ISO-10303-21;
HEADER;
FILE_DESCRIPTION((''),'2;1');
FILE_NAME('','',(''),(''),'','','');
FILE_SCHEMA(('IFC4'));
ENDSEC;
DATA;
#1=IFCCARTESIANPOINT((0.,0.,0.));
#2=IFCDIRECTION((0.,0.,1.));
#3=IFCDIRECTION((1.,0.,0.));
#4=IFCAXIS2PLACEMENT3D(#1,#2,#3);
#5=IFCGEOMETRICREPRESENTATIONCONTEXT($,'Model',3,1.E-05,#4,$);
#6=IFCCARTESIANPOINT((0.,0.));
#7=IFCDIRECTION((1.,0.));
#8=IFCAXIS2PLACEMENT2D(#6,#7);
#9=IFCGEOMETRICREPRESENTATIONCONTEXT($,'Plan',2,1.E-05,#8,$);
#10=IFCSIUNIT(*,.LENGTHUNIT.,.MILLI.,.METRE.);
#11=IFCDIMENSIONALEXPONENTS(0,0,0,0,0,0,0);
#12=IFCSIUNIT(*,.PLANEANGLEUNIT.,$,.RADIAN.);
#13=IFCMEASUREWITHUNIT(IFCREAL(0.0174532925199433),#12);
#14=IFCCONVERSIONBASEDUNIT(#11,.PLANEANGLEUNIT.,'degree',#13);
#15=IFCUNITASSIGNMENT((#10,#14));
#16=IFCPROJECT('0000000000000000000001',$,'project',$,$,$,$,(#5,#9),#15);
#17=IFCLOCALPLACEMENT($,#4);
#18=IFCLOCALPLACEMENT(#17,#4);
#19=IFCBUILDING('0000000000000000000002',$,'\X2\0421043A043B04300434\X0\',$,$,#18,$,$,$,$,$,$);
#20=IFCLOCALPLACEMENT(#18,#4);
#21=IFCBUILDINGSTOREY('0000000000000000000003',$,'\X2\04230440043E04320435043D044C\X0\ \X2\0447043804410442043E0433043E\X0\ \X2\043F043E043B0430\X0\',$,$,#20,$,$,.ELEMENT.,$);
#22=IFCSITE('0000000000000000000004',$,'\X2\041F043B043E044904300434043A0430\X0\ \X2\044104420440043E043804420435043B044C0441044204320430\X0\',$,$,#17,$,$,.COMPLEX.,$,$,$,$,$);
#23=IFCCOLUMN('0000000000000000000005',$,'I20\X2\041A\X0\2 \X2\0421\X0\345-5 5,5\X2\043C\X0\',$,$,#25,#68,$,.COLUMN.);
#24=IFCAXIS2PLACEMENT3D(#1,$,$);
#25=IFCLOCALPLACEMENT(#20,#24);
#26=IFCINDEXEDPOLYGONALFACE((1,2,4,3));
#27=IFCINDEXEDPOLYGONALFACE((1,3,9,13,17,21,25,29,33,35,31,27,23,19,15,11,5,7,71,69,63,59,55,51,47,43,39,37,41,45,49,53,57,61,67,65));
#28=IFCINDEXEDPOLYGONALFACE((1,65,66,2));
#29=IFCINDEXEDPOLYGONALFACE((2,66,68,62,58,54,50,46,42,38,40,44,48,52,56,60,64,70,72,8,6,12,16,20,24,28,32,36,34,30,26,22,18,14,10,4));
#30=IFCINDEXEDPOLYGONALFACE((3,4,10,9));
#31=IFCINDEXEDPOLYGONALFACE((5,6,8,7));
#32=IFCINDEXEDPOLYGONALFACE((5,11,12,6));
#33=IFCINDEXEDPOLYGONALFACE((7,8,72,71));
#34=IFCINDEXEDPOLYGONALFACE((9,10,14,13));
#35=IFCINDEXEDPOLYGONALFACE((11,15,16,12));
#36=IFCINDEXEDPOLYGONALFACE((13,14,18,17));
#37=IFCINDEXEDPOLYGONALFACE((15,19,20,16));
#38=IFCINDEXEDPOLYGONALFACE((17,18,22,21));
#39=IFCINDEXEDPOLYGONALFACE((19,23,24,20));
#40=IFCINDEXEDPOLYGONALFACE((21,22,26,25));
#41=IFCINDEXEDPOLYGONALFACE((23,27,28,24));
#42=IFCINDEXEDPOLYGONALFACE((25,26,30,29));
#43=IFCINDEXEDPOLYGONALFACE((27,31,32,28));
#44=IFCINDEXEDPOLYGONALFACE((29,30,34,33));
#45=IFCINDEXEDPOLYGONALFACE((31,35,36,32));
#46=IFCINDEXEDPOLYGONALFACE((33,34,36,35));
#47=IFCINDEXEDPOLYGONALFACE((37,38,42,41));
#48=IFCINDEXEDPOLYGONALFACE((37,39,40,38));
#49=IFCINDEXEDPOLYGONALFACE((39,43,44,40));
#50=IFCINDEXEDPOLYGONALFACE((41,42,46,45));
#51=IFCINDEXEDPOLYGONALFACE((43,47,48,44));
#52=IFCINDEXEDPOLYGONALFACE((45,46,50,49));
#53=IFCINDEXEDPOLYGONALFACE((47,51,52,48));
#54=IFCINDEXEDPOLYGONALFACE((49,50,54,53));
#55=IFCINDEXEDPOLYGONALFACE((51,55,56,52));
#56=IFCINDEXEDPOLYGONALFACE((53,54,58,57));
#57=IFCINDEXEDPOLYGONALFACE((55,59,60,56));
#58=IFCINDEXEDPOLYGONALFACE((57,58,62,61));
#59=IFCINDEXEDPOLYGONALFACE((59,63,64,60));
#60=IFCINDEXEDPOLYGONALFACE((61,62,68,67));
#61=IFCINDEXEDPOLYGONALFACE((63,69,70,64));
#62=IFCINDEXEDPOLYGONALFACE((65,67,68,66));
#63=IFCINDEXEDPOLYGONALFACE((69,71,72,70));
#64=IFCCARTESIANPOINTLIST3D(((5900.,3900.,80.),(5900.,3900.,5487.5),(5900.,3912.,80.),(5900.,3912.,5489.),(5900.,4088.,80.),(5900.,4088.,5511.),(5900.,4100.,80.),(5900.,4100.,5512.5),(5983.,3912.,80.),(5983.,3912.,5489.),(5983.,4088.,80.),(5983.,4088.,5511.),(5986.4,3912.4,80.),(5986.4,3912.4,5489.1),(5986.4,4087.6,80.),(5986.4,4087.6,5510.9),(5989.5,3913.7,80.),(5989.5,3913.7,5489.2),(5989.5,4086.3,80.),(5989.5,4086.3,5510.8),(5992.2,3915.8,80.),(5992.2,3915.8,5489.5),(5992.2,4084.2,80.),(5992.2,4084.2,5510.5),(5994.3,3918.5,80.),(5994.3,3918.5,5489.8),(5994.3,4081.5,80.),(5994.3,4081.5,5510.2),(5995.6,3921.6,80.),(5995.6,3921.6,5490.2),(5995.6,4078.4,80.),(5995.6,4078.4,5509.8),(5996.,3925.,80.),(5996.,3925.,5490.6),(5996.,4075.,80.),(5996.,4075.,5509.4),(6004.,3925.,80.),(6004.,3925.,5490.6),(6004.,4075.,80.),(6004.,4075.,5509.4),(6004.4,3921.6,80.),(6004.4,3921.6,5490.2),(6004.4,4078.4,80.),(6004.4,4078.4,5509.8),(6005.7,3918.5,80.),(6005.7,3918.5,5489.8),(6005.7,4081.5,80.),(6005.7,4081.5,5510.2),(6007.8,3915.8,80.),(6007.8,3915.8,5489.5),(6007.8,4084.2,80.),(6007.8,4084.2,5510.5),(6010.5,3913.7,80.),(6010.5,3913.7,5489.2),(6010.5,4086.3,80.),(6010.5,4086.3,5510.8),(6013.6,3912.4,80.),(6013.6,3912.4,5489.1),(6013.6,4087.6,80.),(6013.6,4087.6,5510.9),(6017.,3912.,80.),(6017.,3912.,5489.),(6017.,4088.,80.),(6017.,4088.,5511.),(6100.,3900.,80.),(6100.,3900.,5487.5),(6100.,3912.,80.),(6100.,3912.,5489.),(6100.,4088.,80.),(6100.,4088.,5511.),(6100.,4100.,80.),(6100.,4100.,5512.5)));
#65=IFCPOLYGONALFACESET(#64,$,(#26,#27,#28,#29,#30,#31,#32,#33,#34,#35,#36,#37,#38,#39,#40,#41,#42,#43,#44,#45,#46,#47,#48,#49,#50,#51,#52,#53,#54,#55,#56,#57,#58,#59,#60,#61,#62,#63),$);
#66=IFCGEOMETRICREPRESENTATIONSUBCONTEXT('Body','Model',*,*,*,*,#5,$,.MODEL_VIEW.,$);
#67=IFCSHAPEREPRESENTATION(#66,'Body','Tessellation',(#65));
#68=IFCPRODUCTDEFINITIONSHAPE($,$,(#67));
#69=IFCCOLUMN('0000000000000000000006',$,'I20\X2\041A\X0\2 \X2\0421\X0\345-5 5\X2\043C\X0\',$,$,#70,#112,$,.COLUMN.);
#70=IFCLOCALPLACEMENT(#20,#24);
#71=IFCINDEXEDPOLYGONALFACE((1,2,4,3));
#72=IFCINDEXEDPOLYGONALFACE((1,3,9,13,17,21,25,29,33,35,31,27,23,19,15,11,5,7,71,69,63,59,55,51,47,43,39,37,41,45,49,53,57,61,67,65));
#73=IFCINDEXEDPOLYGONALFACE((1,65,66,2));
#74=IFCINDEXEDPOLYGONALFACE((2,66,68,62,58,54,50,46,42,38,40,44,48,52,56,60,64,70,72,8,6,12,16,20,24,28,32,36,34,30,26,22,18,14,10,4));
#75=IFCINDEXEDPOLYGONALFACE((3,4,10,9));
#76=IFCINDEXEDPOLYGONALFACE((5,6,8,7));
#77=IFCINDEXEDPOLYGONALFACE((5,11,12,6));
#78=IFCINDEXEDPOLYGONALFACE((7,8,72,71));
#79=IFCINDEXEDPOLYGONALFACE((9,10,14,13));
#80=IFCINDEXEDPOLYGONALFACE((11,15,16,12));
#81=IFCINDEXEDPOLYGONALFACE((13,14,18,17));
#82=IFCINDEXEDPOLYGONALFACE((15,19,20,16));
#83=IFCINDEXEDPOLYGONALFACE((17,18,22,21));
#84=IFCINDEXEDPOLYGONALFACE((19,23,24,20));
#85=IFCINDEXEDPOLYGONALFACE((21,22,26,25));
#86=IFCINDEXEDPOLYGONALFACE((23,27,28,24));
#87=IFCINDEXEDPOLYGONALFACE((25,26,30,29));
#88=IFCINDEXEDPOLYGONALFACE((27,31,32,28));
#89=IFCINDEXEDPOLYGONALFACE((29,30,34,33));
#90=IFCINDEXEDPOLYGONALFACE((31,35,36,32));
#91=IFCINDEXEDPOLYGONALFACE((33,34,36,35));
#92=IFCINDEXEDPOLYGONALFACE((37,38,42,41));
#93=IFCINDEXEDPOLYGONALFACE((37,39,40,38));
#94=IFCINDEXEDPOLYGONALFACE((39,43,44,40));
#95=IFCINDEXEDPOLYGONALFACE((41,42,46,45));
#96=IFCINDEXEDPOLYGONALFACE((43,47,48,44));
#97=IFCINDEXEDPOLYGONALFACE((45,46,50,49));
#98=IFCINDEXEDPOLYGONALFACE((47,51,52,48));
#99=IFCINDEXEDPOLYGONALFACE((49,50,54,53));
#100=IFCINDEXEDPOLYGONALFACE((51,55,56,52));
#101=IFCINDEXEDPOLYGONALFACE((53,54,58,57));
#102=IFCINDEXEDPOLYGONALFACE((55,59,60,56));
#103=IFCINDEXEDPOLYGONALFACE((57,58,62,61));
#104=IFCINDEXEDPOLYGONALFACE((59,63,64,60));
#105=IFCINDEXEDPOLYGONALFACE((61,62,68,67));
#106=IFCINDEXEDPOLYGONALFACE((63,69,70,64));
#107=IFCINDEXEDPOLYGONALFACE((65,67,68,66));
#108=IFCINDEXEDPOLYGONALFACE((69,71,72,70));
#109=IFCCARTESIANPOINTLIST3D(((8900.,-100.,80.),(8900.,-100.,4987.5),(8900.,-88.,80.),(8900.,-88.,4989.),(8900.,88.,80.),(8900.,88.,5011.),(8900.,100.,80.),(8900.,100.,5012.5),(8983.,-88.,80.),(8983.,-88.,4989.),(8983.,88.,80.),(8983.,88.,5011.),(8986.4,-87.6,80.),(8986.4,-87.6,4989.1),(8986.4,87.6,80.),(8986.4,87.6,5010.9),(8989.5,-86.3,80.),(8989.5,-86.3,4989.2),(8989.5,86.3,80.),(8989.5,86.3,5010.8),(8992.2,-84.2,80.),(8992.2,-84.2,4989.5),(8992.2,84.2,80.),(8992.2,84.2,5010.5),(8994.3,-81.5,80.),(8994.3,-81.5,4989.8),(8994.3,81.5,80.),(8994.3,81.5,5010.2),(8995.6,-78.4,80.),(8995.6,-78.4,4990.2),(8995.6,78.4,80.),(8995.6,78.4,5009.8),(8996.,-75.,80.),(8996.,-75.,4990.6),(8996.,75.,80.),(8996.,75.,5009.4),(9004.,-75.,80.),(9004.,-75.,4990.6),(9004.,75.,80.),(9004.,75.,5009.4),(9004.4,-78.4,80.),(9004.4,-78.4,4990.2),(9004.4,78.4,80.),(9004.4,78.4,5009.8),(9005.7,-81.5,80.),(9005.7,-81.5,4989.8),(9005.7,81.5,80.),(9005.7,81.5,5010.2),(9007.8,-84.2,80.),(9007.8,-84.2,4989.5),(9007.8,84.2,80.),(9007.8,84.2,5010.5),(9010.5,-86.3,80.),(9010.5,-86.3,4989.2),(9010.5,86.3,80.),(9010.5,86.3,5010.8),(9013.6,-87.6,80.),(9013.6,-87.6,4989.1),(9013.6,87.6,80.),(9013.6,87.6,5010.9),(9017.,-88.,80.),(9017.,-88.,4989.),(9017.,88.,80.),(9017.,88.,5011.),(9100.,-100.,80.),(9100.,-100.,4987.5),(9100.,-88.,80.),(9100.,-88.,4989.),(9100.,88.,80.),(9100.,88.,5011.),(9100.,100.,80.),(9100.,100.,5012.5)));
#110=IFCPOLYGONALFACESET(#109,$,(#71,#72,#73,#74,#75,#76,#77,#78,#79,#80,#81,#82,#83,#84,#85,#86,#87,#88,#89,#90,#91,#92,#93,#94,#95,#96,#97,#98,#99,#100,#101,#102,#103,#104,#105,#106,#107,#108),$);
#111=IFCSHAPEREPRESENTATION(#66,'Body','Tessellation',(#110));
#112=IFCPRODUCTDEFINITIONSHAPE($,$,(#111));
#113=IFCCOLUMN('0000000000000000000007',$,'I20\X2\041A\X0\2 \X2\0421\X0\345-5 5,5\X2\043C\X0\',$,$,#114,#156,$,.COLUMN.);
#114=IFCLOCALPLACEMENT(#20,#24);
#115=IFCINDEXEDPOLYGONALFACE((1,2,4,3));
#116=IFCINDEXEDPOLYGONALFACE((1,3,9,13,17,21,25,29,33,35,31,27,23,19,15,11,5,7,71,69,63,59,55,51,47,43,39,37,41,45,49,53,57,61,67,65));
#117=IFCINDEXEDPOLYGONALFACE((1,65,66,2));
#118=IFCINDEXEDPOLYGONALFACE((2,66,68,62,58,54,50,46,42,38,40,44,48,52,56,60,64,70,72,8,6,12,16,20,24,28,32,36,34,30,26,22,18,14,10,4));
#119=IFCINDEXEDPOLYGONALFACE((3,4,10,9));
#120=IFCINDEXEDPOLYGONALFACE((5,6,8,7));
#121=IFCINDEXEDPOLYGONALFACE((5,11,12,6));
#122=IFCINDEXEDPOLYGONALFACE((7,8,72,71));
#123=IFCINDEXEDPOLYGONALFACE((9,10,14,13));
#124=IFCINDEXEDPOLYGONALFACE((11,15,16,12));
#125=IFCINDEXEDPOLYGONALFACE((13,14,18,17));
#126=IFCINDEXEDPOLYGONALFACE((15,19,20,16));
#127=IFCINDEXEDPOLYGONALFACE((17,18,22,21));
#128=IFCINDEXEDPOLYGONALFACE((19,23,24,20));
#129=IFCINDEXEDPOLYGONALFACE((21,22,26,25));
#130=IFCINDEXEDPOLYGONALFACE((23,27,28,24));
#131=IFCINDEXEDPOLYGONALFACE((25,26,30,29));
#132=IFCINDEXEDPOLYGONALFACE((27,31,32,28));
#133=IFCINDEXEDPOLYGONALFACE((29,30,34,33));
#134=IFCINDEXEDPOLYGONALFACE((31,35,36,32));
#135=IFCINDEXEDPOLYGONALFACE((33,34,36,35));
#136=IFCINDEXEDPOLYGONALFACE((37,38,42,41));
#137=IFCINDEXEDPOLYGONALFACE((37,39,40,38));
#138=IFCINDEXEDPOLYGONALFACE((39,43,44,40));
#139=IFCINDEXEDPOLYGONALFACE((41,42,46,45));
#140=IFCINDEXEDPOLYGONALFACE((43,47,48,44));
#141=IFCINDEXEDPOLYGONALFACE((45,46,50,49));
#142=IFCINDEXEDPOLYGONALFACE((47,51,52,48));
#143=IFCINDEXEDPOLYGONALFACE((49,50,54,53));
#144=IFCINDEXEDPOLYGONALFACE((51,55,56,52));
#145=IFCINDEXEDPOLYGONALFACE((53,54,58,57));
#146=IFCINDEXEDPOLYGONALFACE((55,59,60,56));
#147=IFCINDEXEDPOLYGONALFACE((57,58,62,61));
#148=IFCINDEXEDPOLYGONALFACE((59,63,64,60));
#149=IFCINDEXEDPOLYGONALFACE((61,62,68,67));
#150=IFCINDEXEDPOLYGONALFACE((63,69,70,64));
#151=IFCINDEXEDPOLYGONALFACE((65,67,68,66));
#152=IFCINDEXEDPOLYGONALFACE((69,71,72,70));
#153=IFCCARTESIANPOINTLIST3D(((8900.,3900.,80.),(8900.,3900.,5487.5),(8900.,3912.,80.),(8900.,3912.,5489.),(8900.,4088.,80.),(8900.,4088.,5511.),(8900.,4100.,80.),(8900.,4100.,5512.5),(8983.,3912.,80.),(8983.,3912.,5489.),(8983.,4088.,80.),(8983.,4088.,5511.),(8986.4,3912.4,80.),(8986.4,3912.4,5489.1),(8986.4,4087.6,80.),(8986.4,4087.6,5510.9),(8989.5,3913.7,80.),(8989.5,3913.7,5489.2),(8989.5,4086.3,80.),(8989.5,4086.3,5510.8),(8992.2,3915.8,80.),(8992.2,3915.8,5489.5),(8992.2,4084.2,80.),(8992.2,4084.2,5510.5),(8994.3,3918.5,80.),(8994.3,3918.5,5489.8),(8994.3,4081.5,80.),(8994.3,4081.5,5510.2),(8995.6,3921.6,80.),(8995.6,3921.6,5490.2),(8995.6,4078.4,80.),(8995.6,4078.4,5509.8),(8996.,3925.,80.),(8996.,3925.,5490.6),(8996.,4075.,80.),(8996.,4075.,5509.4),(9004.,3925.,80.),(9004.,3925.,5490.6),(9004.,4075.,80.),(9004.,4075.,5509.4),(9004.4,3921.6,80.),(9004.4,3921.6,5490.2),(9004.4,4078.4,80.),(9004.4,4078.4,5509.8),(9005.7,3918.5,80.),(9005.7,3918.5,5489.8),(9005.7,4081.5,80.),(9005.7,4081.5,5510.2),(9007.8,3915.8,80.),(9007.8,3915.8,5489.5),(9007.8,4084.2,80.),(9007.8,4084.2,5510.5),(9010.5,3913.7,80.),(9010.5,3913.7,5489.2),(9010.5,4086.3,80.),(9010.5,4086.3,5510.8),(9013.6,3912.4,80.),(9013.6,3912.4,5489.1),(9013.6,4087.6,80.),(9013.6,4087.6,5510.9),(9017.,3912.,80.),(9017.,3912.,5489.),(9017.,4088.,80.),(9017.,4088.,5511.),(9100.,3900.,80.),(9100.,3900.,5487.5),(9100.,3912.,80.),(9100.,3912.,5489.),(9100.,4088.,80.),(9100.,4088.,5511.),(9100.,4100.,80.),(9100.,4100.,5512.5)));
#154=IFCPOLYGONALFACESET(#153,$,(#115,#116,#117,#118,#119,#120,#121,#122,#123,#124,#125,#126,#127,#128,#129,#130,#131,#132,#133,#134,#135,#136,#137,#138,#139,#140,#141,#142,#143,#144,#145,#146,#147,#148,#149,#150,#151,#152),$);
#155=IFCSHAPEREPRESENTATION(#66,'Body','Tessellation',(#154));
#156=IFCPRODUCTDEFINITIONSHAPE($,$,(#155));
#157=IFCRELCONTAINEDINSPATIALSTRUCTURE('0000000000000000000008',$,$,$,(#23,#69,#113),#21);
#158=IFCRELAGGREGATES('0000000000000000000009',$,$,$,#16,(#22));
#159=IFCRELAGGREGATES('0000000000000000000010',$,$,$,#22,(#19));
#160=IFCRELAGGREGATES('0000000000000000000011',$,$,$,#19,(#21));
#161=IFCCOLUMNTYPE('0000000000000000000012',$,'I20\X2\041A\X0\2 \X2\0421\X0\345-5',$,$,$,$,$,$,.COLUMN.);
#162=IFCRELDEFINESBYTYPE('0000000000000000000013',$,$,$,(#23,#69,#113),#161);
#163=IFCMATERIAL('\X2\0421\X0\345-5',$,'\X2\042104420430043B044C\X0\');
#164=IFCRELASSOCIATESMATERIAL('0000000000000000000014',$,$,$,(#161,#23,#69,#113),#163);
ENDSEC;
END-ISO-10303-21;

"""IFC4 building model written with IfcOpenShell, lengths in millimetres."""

from ifc_helpers import new_model, entity, si_unit, converted_unit, frame, origin_with_axes, origin_2d_with_axis, place, context, subcontext, project, spatial, i_section, extrude, boolean, clip, halfspace, material, material_profile, profile_set, profile_usage, type_object, element, save


model = new_model("IFC4")

# Units and contexts
model_context = context("Model", 3, precision=1e-05, world=origin_with_axes())
plan_context = context("Plan", 2, precision=1e-05, world=origin_2d_with_axis())
body_context = subcontext(model_context, "Body", "Model", "MODEL_VIEW")
ifc_project = project(units=[si_unit("LENGTHUNIT", "METRE", prefix="MILLI"), converted_unit("PLANEANGLEUNIT", "degree", entity("IfcReal", 0.0174532925199433), si_unit("PLANEANGLEUNIT", "RADIAN"), dimensions=[0, 0, 0, 0, 0, 0, 0])], contexts=[model_context, plan_context])

# Site, building, storey
site_placement = place(None, origin_with_axes())
site = spatial("IfcSite", under=ifc_project, at=site_placement, Name="Площадка строительства", CompositionType="COMPLEX")
building_placement = place(site_placement, origin_with_axes())
building = spatial("IfcBuilding", under=site, at=building_placement, Name="Склад")
storey_placement = place(building_placement, origin_with_axes())
storey = spatial("IfcBuildingStorey", under=building, at=storey_placement, Name="Уровень чистого пола", CompositionType="ELEMENT")

# Shared definitions
ifc_material_1 = material(Name="С345-5", Category="Сталь")
ifc_material_profile_1 = material_profile(ifc_material_1, i_section(OverallWidth=200.0, OverallDepth=200.0, WebThickness=8.0, FlangeThickness=12.0, FilletRadius=13.0, FlangeEdgeRadius=0.0, FlangeSlope=0.0))
ifc_profile_set_1 = profile_set([ifc_material_profile_1], Name="I20К2_С345-5")
ifc_profile_usage_1 = profile_usage(ifc_profile_set_1, cardinal=5)
column_type = type_object("IfcColumnType", Name="I20К2 С345-5", PredefinedType="COLUMN", material=ifc_profile_set_1)

# Columns
column_1_placement = place(storey_placement, frame((6000.0, 4000.0, 0.0), z_axis=(0.0, 0.0, 1.0), x_axis=(1.0, 0.0, 0.0)))
element("IfcColumn", 1, at=column_1_placement, inside=storey, type_object=column_type, material=ifc_profile_usage_1, Name="I20К2 С345-5 5,5м", PredefinedType="COLUMN", context=body_context, shape_type="Clipping", body=[
    boolean("DIFFERENCE", clip(extrude(i_section(OverallWidth=200.0, OverallDepth=200.0, WebThickness=8.0, FlangeThickness=12.0, FilletRadius=13.0, FlangeEdgeRadius=0.0, FlangeSlope=0.0), origin_with_axes(), (0.0, 0.0, 1.0), 5700.0), halfspace(frame((0.0, -4298.5, 4962.7), z_axis=(0.0, -0.124035, 0.992278), x_axis=(0.0, 0.992278, 0.124035)), False)), halfspace(frame((0.0, 0.0, 80.0), z_axis=(0.0, 0.0, -1.0), x_axis=(1.0, 0.0, 0.0)), False)),
])
column_2_placement = place(storey_placement, frame((9000.0, 0.0, 0.0), z_axis=(0.0, 0.0, 1.0), x_axis=(1.0, 0.0, 0.0)))
element("IfcColumn", 2, at=column_2_placement, inside=storey, type_object=column_type, material=ifc_profile_usage_1, Name="I20К2 С345-5 5м", PredefinedType="COLUMN", context=body_context, shape_type="Clipping", body=[
    boolean("DIFFERENCE", clip(extrude(i_section(OverallWidth=200.0, OverallDepth=200.0, WebThickness=8.0, FlangeThickness=12.0, FilletRadius=13.0, FlangeEdgeRadius=0.0, FlangeSlope=0.0), origin_with_axes(), (0.0, 0.0, 1.0), 5200.0), halfspace(frame((0.0, -298.5, 4962.7), z_axis=(0.0, -0.124035, 0.992278), x_axis=(0.0, 0.992278, 0.124035)), False)), halfspace(frame((0.0, 0.0, 80.0), z_axis=(0.0, 0.0, -1.0), x_axis=(1.0, 0.0, 0.0)), False)),
])
column_3_placement = place(storey_placement, frame((9000.0, 4000.0, 0.0), z_axis=(0.0, 0.0, 1.0), x_axis=(1.0, 0.0, 0.0)))
element("IfcColumn", 3, at=column_3_placement, inside=storey, type_object=column_type, material=ifc_profile_usage_1, Name="I20К2 С345-5 5,5м", PredefinedType="COLUMN", context=body_context, shape_type="Clipping", body=[
    boolean("DIFFERENCE", clip(extrude(i_section(OverallWidth=200.0, OverallDepth=200.0, WebThickness=8.0, FlangeThickness=12.0, FilletRadius=13.0, FlangeEdgeRadius=0.0, FlangeSlope=0.0), origin_with_axes(), (0.0, 0.0, 1.0), 5700.0), halfspace(frame((0.0, -4298.5, 4962.7), z_axis=(0.0, -0.124035, 0.992278), x_axis=(0.0, 0.992278, 0.124035)), False)), halfspace(frame((0.0, 0.0, 80.0), z_axis=(0.0, 0.0, -1.0), x_axis=(1.0, 0.0, 0.0)), False)),
])

save(model, "model.ifc")
